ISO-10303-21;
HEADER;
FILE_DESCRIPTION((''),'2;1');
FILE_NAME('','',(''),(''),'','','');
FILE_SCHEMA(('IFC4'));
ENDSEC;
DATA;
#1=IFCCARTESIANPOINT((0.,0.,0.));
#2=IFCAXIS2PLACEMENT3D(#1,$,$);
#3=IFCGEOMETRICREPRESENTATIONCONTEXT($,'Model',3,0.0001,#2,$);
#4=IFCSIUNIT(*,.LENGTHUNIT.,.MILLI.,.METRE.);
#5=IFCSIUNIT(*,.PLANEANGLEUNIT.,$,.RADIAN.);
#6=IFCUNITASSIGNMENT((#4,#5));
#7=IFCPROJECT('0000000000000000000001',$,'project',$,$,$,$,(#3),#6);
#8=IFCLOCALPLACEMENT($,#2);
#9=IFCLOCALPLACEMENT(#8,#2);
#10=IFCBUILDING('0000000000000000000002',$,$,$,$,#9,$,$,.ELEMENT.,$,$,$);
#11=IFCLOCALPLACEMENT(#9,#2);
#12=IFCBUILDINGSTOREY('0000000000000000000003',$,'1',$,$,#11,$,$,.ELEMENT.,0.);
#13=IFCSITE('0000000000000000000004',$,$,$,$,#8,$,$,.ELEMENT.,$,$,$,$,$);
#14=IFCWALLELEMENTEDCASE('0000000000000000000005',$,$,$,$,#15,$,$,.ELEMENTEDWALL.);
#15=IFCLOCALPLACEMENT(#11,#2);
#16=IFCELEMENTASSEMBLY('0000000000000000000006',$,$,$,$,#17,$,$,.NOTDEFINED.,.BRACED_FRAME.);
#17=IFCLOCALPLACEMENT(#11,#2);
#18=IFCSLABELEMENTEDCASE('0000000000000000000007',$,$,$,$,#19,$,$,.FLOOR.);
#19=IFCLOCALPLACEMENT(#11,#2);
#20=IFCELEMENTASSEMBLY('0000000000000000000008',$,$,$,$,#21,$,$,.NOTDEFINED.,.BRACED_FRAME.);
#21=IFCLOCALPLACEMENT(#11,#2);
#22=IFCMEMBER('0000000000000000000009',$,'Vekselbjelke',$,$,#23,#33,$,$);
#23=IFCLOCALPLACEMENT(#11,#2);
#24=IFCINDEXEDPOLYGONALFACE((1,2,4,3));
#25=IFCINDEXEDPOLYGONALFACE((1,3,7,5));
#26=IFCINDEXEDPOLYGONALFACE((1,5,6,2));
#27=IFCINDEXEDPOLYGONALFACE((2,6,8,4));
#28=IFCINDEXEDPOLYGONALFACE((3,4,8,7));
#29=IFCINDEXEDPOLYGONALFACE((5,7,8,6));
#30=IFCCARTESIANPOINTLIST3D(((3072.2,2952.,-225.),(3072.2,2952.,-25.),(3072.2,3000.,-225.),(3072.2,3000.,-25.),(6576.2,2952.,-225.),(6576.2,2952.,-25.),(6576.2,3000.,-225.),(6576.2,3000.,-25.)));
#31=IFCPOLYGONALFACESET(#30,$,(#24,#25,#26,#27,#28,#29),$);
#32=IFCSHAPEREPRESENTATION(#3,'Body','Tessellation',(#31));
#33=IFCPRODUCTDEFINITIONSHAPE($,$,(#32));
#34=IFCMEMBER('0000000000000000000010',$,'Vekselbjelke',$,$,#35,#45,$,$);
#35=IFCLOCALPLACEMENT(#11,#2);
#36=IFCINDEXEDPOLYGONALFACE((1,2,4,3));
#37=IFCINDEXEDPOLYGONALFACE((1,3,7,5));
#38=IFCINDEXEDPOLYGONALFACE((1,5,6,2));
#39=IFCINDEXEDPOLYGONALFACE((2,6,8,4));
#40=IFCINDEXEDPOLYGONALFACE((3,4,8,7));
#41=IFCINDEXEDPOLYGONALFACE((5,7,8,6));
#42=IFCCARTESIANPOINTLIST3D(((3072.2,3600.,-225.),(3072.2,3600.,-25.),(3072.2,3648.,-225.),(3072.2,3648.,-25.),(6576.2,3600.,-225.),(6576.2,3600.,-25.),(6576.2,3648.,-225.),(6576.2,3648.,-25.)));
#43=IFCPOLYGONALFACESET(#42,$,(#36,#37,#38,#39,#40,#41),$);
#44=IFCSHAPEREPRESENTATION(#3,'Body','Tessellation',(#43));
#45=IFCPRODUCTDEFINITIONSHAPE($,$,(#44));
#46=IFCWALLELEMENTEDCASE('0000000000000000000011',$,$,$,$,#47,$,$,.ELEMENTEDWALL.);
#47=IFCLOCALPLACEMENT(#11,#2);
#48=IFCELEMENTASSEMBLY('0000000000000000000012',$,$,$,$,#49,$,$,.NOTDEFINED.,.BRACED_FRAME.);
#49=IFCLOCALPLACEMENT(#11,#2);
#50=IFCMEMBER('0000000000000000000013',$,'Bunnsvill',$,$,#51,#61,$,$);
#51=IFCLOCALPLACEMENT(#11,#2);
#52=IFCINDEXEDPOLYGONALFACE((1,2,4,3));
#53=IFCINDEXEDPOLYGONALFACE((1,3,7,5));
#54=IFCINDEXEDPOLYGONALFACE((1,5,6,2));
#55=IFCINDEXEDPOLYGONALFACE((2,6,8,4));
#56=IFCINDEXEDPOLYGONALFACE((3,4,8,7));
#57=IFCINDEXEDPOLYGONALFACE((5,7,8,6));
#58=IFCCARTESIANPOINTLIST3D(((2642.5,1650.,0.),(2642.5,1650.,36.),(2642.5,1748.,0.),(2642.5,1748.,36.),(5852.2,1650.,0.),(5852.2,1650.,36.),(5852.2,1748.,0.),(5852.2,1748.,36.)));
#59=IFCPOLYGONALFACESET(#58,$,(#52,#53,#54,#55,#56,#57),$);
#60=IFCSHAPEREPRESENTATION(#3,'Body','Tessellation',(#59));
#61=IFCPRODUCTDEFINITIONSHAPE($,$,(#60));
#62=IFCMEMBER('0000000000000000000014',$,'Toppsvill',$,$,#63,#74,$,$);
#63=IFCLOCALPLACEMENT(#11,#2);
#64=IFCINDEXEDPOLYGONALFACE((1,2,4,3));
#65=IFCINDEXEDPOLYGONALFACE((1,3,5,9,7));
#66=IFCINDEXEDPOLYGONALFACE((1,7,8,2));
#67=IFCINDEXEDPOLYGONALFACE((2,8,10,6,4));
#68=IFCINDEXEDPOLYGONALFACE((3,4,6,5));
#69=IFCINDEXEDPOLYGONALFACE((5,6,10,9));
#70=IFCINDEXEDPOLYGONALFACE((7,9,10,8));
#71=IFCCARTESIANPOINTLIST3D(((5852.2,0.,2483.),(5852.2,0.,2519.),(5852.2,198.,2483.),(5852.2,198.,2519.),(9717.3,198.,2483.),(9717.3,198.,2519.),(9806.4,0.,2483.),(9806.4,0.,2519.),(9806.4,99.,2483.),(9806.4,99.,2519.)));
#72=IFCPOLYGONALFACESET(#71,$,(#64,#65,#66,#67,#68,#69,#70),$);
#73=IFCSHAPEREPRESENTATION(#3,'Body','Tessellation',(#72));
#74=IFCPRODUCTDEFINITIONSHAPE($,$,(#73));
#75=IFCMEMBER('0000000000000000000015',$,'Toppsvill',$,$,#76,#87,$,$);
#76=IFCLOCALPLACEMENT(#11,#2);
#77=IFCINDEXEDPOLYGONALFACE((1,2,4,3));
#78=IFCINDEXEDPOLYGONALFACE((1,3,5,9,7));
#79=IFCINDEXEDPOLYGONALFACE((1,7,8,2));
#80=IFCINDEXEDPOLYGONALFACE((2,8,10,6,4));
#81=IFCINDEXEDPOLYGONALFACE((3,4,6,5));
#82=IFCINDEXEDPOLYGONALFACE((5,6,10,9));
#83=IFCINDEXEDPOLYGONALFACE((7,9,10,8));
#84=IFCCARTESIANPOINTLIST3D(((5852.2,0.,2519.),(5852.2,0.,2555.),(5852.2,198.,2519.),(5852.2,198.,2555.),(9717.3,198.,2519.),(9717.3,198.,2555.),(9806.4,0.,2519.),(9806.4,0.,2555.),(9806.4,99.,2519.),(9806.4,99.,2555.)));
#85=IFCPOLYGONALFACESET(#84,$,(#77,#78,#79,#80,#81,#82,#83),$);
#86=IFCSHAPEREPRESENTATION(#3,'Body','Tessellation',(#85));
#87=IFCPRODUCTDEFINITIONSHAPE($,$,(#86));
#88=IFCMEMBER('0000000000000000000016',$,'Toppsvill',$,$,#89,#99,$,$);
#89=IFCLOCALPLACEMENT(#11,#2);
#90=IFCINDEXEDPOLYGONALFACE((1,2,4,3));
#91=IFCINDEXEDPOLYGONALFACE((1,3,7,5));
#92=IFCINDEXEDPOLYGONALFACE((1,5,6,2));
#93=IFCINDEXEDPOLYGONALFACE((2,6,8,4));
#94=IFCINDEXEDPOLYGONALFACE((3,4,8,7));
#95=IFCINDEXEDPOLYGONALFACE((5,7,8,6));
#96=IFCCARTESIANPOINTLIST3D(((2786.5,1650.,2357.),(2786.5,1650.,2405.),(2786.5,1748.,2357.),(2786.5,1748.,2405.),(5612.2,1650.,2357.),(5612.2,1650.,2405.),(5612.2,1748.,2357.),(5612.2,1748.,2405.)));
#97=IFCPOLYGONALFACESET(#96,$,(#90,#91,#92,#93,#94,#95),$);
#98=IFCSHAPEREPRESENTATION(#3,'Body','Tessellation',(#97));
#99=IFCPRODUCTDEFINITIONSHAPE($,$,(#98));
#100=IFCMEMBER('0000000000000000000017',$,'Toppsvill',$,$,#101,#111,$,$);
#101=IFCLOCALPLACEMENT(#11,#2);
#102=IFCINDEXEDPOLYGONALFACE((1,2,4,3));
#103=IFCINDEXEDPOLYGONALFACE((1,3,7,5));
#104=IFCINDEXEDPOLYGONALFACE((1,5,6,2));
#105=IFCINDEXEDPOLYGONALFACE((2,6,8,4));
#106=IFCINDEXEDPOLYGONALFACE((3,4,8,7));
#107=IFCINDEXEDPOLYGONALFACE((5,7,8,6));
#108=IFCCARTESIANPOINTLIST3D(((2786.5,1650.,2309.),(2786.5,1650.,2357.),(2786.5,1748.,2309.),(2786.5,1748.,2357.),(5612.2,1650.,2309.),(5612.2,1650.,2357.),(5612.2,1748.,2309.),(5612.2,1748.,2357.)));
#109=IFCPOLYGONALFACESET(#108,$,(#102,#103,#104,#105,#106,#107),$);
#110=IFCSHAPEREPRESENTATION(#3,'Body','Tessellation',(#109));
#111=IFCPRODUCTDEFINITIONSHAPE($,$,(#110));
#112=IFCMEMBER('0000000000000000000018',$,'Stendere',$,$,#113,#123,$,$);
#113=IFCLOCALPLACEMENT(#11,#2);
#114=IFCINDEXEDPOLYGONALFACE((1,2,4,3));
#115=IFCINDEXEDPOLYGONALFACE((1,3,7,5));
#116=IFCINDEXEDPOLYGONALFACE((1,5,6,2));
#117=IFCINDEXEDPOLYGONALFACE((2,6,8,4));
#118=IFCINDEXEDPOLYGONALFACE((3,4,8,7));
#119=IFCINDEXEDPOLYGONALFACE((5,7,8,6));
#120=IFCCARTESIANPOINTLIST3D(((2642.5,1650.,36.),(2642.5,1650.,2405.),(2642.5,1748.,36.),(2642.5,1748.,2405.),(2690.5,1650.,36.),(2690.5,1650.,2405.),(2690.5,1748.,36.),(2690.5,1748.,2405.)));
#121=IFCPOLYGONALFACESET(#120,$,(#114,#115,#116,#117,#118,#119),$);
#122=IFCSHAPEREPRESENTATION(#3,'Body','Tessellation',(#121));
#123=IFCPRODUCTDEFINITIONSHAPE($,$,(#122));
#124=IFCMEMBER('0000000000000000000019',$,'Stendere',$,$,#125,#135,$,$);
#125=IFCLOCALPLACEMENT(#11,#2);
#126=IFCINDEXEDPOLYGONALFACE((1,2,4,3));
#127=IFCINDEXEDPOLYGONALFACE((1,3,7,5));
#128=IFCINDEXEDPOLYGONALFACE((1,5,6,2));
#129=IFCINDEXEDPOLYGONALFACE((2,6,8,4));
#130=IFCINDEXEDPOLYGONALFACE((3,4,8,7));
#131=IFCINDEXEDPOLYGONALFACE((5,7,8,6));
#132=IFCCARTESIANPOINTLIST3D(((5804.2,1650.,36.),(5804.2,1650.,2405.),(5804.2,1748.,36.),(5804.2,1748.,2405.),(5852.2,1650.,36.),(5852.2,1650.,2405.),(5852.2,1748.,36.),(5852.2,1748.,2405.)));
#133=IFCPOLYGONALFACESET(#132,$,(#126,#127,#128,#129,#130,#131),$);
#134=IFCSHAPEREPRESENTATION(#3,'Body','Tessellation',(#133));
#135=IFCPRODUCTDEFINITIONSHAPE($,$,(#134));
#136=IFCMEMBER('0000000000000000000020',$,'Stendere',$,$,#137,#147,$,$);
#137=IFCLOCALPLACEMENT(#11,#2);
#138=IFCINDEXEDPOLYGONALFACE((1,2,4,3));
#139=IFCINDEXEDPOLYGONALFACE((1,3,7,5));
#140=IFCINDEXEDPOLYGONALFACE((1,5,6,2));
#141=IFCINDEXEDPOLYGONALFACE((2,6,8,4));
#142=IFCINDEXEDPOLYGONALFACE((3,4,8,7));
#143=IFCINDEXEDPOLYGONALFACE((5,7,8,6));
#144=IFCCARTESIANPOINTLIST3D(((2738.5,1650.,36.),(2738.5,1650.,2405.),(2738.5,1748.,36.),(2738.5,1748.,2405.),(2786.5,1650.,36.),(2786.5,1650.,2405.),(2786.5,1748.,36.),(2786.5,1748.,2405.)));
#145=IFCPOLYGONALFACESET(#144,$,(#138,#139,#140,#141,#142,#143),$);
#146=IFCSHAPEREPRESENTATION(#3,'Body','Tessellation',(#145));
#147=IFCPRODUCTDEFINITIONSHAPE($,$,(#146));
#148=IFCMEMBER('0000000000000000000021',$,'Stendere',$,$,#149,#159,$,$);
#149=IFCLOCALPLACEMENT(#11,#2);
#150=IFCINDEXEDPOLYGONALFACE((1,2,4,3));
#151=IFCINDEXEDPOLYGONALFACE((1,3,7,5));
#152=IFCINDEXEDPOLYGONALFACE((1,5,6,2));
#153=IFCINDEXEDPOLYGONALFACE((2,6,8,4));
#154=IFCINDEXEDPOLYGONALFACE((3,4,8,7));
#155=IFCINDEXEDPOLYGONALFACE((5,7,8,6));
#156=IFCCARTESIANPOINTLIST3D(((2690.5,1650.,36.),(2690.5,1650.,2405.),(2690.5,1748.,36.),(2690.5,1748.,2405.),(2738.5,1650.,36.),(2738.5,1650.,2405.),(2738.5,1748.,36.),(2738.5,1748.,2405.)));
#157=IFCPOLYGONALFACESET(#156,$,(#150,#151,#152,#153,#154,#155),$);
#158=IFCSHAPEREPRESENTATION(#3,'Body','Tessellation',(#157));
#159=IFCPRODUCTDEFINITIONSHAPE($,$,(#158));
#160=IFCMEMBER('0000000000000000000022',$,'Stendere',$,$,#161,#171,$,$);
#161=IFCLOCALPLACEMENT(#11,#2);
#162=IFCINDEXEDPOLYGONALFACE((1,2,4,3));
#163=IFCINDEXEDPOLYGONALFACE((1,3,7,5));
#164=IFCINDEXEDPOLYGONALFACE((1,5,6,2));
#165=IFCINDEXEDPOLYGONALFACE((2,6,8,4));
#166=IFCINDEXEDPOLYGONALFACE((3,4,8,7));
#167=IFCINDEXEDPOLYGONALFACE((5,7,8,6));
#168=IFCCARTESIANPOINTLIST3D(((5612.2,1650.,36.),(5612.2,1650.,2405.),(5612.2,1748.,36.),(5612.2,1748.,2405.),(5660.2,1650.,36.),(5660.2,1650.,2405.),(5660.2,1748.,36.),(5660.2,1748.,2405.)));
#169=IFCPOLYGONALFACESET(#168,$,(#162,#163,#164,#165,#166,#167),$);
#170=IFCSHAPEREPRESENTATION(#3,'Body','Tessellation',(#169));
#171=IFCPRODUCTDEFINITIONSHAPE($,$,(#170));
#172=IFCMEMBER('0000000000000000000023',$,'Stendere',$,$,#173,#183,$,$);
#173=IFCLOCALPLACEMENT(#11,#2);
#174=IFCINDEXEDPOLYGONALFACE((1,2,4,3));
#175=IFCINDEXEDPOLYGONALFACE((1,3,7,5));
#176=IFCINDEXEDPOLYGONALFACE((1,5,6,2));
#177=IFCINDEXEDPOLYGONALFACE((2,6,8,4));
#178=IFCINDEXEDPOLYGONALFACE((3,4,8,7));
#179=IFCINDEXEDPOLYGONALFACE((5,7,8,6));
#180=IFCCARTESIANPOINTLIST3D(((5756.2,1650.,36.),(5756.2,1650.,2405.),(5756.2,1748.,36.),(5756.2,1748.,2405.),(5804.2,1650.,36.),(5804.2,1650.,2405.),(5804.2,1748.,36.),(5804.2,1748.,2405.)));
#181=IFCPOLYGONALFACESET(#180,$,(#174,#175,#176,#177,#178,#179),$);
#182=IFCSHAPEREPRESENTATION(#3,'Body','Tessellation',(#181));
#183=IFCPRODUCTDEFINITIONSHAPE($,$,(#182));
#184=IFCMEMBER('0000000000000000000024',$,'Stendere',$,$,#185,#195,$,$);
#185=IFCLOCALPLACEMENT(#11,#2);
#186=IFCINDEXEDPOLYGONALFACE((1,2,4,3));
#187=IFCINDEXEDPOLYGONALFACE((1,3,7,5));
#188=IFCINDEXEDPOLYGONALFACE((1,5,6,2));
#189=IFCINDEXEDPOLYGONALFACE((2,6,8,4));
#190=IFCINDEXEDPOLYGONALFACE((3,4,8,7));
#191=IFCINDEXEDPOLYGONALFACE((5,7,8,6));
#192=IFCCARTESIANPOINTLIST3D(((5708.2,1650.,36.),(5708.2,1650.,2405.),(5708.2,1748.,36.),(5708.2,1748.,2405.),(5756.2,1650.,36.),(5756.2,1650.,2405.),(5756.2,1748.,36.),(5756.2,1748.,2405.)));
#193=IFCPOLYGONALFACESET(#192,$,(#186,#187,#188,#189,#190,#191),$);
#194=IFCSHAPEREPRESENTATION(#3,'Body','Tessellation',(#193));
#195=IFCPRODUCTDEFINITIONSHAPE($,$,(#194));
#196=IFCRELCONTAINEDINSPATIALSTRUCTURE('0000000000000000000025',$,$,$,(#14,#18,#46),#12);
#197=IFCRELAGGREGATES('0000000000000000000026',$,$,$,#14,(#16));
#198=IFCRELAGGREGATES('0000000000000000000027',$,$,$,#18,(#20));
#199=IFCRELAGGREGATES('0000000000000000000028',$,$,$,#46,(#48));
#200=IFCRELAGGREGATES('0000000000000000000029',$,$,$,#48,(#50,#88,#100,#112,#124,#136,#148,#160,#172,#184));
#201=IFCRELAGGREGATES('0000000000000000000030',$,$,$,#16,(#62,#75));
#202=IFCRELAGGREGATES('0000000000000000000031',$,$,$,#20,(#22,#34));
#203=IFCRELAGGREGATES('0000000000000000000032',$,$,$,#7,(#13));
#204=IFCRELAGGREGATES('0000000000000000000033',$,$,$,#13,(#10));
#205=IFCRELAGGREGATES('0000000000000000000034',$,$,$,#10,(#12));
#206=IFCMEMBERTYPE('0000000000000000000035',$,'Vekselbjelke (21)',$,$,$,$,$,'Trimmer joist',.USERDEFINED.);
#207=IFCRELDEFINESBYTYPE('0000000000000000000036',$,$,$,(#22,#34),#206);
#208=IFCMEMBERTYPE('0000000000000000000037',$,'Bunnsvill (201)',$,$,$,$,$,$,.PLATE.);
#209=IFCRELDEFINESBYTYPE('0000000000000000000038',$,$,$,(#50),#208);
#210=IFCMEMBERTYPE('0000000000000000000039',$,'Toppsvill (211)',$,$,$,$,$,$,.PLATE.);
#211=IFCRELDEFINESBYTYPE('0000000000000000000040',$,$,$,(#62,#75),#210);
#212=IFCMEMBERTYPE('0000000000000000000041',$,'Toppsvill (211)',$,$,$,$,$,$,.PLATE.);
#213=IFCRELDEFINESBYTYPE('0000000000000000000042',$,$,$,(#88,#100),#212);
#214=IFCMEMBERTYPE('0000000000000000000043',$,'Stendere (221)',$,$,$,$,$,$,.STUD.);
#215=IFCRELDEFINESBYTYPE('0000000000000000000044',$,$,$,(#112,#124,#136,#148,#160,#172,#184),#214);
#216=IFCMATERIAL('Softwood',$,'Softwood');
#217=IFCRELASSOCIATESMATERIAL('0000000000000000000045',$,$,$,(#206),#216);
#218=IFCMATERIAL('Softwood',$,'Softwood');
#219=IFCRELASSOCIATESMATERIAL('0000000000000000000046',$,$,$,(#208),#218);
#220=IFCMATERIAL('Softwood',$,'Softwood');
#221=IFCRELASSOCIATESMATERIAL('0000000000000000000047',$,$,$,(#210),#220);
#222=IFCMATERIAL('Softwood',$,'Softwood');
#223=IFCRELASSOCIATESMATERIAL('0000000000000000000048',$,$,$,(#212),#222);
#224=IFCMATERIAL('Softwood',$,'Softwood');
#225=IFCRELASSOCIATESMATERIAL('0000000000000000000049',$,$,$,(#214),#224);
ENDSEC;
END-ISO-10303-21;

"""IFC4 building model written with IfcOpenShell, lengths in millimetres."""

from ifc_helpers import new_model, si_unit, frame, origin, place, context, project, spatial, rectangle, extrude, clip, halfspace, material, material_profile, profile_set, type_object, element, aggregate, save


model = new_model("IFC4")

# Units and contexts
model_context = context("Model", 3, precision=0.0001, world=origin())
ifc_project = project(units=[si_unit("LENGTHUNIT", "METRE", prefix="MILLI"), si_unit("PLANEANGLEUNIT", "RADIAN")], contexts=[model_context])

# Site, building, storey
site_placement = place(None, origin())
site = spatial("IfcSite", under=ifc_project, at=site_placement, CompositionType="ELEMENT")
building_placement = place(site_placement, origin())
building = spatial("IfcBuilding", under=site, at=building_placement, CompositionType="ELEMENT")
storey_placement = place(building_placement, origin())
storey = spatial("IfcBuildingStorey", under=building, at=storey_placement, Name="1", CompositionType="ELEMENT", Elevation=0.0)

# Wall, element assembly
wall_1_placement = place(storey_placement, frame((5852.2, 198.0, 535.0), z_axis=(0.0, -1.0, 0.0)))
wall_1 = element("IfcWallElementedCase", 1, at=wall_1_placement, inside=storey, PredefinedType="ELEMENTEDWALL")
assembly_1_placement = place(wall_1_placement, origin())
assembly_1 = element("IfcElementAssembly", 2, at=assembly_1_placement, AssemblyPlace="NOTDEFINED", PredefinedType="BRACED_FRAME")
aggregate(wall_1, [assembly_1])

# Slab, element assembly
slab_placement = place(storey_placement, origin())
slab = element("IfcSlabElementedCase", 3, at=slab_placement, inside=storey, PredefinedType="FLOOR")
assembly_2_placement = place(slab_placement, frame((0.0, 0.0, -225.0)))
assembly_2 = element("IfcElementAssembly", 4, at=assembly_2_placement, AssemblyPlace="NOTDEFINED", PredefinedType="BRACED_FRAME")
aggregate(slab, [assembly_2])

# Members
ifc_material_1 = material(Name="Softwood", Category="Softwood")
ifc_material_profile_1 = material_profile(ifc_material_1, rectangle(XDim=48.0, YDim=200.0), Name="Vekselbjelke (21)")
ifc_profile_set_1 = profile_set([ifc_material_profile_1])
member_type_1 = type_object("IfcMemberType", Name="Vekselbjelke (21)", ElementType="Trimmer joist", PredefinedType="USERDEFINED", material=ifc_profile_set_1)
member_1_placement = place(assembly_2_placement, frame((3072.2, 2976.0, 0.0), z_axis=(1.0, 0.0, 0.0), x_axis=(0.0, 1.0, 0.0)))
member_1 = element("IfcMember", 5, at=member_1_placement, type_object=member_type_1, Name="Vekselbjelke", context=model_context, shape_type="SweptSolid", body=[
    extrude(rectangle(XDim=48.0, YDim=200.0), frame((0.0, 100.0, 0.0)), (0.0, 0.0, 1.0), 3504.0),
])
member_2_placement = place(assembly_2_placement, frame((3072.2, 3624.0, 0.0), z_axis=(1.0, 0.0, 0.0), x_axis=(0.0, 1.0, 0.0)))
member_2 = element("IfcMember", 6, at=member_2_placement, type_object=member_type_1, Name="Vekselbjelke", context=model_context, shape_type="SweptSolid", body=[
    extrude(rectangle(XDim=48.0, YDim=200.0), frame((0.0, 100.0, 0.0)), (0.0, 0.0, 1.0), 3504.0),
])

# Wall, element assembly, member
wall_2_placement = place(storey_placement, frame((2642.5, 1748.0, 0.0), z_axis=(0.0, -1.0, 0.0)))
wall_2 = element("IfcWallElementedCase", 7, at=wall_2_placement, inside=storey, PredefinedType="ELEMENTEDWALL")
assembly_3_placement = place(wall_2_placement, origin())
assembly_3 = element("IfcElementAssembly", 8, at=assembly_3_placement, AssemblyPlace="NOTDEFINED", PredefinedType="BRACED_FRAME")
aggregate(wall_2, [assembly_3])
ifc_material_2 = material(Name="Softwood", Category="Softwood")
ifc_material_profile_2 = material_profile(ifc_material_2, rectangle(XDim=36.0, YDim=98.0), Name="Bunnsvill (201)")
ifc_profile_set_2 = profile_set([ifc_material_profile_2])
member_type_2 = type_object("IfcMemberType", Name="Bunnsvill (201)", PredefinedType="PLATE", material=ifc_profile_set_2)
member_3_placement = place(assembly_3_placement, frame((0.0, 18.0, 0.0), z_axis=(1.0, 0.0, 0.0), x_axis=(0.0, 1.0, 0.0)))
member_3 = element("IfcMember", 9, at=member_3_placement, type_object=member_type_2, Name="Bunnsvill", context=model_context, shape_type="SweptSolid", body=[
    extrude(rectangle(XDim=36.0, YDim=98.0), frame((0.0, 49.0, 0.0)), (0.0, 0.0, 1.0), 3209.7),
])

# Members
ifc_material_3 = material(Name="Softwood", Category="Softwood")
ifc_material_profile_3 = material_profile(ifc_material_3, rectangle(XDim=36.0, YDim=198.0), Name="Toppsvill (211)")
ifc_profile_set_3 = profile_set([ifc_material_profile_3])
member_type_3 = type_object("IfcMemberType", Name="Toppsvill (211)", PredefinedType="PLATE", material=ifc_profile_set_3)
member_4_placement = place(assembly_1_placement, frame((0.0, 1966.0, 0.0), z_axis=(1.0, 0.0, 0.0), x_axis=(0.0, 1.0, 0.0)))
member_4 = element("IfcMember", 10, at=member_4_placement, type_object=member_type_3, Name="Toppsvill", context=model_context, shape_type="Clipping", body=[
    clip(extrude(rectangle(XDim=36.0, YDim=198.0), frame((0.0, 99.0, 0.0)), (0.0, 0.0, 1.0), 3954.3), halfspace(frame((0.0, 99.0, 3954.3), z_axis=(0.0, -0.669131, 0.743145)), False)),
])
member_5_placement = place(assembly_1_placement, frame((0.0, 2002.0, 0.0), z_axis=(1.0, 0.0, 0.0), x_axis=(0.0, 1.0, 0.0)))
member_5 = element("IfcMember", 11, at=member_5_placement, type_object=member_type_3, Name="Toppsvill", context=model_context, shape_type="Clipping", body=[
    clip(extrude(rectangle(XDim=36.0, YDim=198.0), frame((0.0, 99.0, 0.0)), (0.0, 0.0, 1.0), 3954.3), halfspace(frame((0.0, 99.0, 3954.3), z_axis=(0.0, -0.669131, 0.743145)), False)),
])
ifc_material_4 = material(Name="Softwood", Category="Softwood")
ifc_material_profile_4 = material_profile(ifc_material_4, rectangle(XDim=48.0, YDim=98.0), Name="Toppsvill (211)")
ifc_profile_set_4 = profile_set([ifc_material_profile_4])
member_type_4 = type_object("IfcMemberType", Name="Toppsvill (211)", PredefinedType="PLATE", material=ifc_profile_set_4)
member_6_placement = place(assembly_3_placement, frame((144.0, 2381.0, 0.0), z_axis=(1.0, 0.0, 0.0), x_axis=(0.0, 1.0, 0.0)))
member_6 = element("IfcMember", 12, at=member_6_placement, type_object=member_type_4, Name="Toppsvill", context=model_context, shape_type="SweptSolid", body=[
    extrude(rectangle(XDim=48.0, YDim=98.0), frame((0.0, 49.0, 0.0)), (0.0, 0.0, 1.0), 2825.7),
])
member_7_placement = place(assembly_3_placement, frame((144.0, 2333.0, 0.0), z_axis=(1.0, 0.0, 0.0), x_axis=(0.0, 1.0, 0.0)))
member_7 = element("IfcMember", 13, at=member_7_placement, type_object=member_type_4, Name="Toppsvill", context=model_context, shape_type="SweptSolid", body=[
    extrude(rectangle(XDim=48.0, YDim=98.0), frame((0.0, 49.0, 0.0)), (0.0, 0.0, 1.0), 2825.7),
])
ifc_material_5 = material(Name="Softwood", Category="Softwood")
ifc_material_profile_5 = material_profile(ifc_material_5, rectangle(XDim=48.0, YDim=98.0), Name="Stendere (221)")
ifc_profile_set_5 = profile_set([ifc_material_profile_5])
member_type_5 = type_object("IfcMemberType", Name="Stendere (221)", PredefinedType="STUD", material=ifc_profile_set_5)
member_8_placement = place(assembly_3_placement, frame((24.0, 36.0, 0.0), z_axis=(0.0, 1.0, 0.0), x_axis=(-1.0, 0.0, 0.0)))
member_8 = element("IfcMember", 14, at=member_8_placement, type_object=member_type_5, Name="Stendere", context=model_context, shape_type="SweptSolid", body=[
    extrude(rectangle(XDim=48.0, YDim=98.0), frame((0.0, 49.0, 0.0)), (0.0, 0.0, 1.0), 2369.0),
])
member_9_placement = place(assembly_3_placement, frame((3185.7, 36.0, 0.0), z_axis=(0.0, 1.0, 0.0), x_axis=(-1.0, 0.0, 0.0)))
member_9 = element("IfcMember", 15, at=member_9_placement, type_object=member_type_5, Name="Stendere", context=model_context, shape_type="SweptSolid", body=[
    extrude(rectangle(XDim=48.0, YDim=98.0), frame((0.0, 49.0, 0.0)), (0.0, 0.0, 1.0), 2369.0),
])
member_10_placement = place(assembly_3_placement, frame((120.0, 36.0, 0.0), z_axis=(0.0, 1.0, 0.0), x_axis=(-1.0, 0.0, 0.0)))
member_10 = element("IfcMember", 16, at=member_10_placement, type_object=member_type_5, Name="Stendere", context=model_context, shape_type="SweptSolid", body=[
    extrude(rectangle(XDim=48.0, YDim=98.0), frame((0.0, 49.0, 0.0)), (0.0, 0.0, 1.0), 2369.0),
])
member_11_placement = place(assembly_3_placement, frame((72.0, 36.0, 0.0), z_axis=(0.0, 1.0, 0.0), x_axis=(-1.0, 0.0, 0.0)))
member_11 = element("IfcMember", 17, at=member_11_placement, type_object=member_type_5, Name="Stendere", context=model_context, shape_type="SweptSolid", body=[
    extrude(rectangle(XDim=48.0, YDim=98.0), frame((0.0, 49.0, 0.0)), (0.0, 0.0, 1.0), 2369.0),
])
member_12_placement = place(assembly_3_placement, frame((2993.7, 36.0, 0.0), z_axis=(0.0, 1.0, 0.0), x_axis=(-1.0, 0.0, 0.0)))
member_12 = element("IfcMember", 18, at=member_12_placement, type_object=member_type_5, Name="Stendere", context=model_context, shape_type="SweptSolid", body=[
    extrude(rectangle(XDim=48.0, YDim=98.0), frame((0.0, 49.0, 0.0)), (0.0, 0.0, 1.0), 2369.0),
])
member_13_placement = place(assembly_3_placement, frame((3137.7, 36.0, 0.0), z_axis=(0.0, 1.0, 0.0), x_axis=(-1.0, 0.0, 0.0)))
member_13 = element("IfcMember", 19, at=member_13_placement, type_object=member_type_5, Name="Stendere", context=model_context, shape_type="Clipping", body=[
    clip(extrude(rectangle(XDim=48.0, YDim=98.0), frame((0.0, 49.0, 0.0)), (0.0, 0.0, 1.0), 2369.0), halfspace(frame((0.0, 49.0, 0.0)), True)),
])
member_14_placement = place(assembly_3_placement, frame((3089.7, 36.0, 0.0), z_axis=(0.0, 1.0, 0.0), x_axis=(-1.0, 0.0, 0.0)))
member_14 = element("IfcMember", 20, at=member_14_placement, type_object=member_type_5, Name="Stendere", context=model_context, shape_type="SweptSolid", body=[
    extrude(rectangle(XDim=48.0, YDim=98.0), frame((0.0, 49.0, 0.0)), (0.0, 0.0, 1.0), 2369.0),
])
aggregate(assembly_3, [member_3, member_6, member_7, member_8, member_9, member_10, member_11, member_12, member_13, member_14])
aggregate(assembly_1, [member_4, member_5])
aggregate(assembly_2, [member_1, member_2])

save(model, "model.ifc")
